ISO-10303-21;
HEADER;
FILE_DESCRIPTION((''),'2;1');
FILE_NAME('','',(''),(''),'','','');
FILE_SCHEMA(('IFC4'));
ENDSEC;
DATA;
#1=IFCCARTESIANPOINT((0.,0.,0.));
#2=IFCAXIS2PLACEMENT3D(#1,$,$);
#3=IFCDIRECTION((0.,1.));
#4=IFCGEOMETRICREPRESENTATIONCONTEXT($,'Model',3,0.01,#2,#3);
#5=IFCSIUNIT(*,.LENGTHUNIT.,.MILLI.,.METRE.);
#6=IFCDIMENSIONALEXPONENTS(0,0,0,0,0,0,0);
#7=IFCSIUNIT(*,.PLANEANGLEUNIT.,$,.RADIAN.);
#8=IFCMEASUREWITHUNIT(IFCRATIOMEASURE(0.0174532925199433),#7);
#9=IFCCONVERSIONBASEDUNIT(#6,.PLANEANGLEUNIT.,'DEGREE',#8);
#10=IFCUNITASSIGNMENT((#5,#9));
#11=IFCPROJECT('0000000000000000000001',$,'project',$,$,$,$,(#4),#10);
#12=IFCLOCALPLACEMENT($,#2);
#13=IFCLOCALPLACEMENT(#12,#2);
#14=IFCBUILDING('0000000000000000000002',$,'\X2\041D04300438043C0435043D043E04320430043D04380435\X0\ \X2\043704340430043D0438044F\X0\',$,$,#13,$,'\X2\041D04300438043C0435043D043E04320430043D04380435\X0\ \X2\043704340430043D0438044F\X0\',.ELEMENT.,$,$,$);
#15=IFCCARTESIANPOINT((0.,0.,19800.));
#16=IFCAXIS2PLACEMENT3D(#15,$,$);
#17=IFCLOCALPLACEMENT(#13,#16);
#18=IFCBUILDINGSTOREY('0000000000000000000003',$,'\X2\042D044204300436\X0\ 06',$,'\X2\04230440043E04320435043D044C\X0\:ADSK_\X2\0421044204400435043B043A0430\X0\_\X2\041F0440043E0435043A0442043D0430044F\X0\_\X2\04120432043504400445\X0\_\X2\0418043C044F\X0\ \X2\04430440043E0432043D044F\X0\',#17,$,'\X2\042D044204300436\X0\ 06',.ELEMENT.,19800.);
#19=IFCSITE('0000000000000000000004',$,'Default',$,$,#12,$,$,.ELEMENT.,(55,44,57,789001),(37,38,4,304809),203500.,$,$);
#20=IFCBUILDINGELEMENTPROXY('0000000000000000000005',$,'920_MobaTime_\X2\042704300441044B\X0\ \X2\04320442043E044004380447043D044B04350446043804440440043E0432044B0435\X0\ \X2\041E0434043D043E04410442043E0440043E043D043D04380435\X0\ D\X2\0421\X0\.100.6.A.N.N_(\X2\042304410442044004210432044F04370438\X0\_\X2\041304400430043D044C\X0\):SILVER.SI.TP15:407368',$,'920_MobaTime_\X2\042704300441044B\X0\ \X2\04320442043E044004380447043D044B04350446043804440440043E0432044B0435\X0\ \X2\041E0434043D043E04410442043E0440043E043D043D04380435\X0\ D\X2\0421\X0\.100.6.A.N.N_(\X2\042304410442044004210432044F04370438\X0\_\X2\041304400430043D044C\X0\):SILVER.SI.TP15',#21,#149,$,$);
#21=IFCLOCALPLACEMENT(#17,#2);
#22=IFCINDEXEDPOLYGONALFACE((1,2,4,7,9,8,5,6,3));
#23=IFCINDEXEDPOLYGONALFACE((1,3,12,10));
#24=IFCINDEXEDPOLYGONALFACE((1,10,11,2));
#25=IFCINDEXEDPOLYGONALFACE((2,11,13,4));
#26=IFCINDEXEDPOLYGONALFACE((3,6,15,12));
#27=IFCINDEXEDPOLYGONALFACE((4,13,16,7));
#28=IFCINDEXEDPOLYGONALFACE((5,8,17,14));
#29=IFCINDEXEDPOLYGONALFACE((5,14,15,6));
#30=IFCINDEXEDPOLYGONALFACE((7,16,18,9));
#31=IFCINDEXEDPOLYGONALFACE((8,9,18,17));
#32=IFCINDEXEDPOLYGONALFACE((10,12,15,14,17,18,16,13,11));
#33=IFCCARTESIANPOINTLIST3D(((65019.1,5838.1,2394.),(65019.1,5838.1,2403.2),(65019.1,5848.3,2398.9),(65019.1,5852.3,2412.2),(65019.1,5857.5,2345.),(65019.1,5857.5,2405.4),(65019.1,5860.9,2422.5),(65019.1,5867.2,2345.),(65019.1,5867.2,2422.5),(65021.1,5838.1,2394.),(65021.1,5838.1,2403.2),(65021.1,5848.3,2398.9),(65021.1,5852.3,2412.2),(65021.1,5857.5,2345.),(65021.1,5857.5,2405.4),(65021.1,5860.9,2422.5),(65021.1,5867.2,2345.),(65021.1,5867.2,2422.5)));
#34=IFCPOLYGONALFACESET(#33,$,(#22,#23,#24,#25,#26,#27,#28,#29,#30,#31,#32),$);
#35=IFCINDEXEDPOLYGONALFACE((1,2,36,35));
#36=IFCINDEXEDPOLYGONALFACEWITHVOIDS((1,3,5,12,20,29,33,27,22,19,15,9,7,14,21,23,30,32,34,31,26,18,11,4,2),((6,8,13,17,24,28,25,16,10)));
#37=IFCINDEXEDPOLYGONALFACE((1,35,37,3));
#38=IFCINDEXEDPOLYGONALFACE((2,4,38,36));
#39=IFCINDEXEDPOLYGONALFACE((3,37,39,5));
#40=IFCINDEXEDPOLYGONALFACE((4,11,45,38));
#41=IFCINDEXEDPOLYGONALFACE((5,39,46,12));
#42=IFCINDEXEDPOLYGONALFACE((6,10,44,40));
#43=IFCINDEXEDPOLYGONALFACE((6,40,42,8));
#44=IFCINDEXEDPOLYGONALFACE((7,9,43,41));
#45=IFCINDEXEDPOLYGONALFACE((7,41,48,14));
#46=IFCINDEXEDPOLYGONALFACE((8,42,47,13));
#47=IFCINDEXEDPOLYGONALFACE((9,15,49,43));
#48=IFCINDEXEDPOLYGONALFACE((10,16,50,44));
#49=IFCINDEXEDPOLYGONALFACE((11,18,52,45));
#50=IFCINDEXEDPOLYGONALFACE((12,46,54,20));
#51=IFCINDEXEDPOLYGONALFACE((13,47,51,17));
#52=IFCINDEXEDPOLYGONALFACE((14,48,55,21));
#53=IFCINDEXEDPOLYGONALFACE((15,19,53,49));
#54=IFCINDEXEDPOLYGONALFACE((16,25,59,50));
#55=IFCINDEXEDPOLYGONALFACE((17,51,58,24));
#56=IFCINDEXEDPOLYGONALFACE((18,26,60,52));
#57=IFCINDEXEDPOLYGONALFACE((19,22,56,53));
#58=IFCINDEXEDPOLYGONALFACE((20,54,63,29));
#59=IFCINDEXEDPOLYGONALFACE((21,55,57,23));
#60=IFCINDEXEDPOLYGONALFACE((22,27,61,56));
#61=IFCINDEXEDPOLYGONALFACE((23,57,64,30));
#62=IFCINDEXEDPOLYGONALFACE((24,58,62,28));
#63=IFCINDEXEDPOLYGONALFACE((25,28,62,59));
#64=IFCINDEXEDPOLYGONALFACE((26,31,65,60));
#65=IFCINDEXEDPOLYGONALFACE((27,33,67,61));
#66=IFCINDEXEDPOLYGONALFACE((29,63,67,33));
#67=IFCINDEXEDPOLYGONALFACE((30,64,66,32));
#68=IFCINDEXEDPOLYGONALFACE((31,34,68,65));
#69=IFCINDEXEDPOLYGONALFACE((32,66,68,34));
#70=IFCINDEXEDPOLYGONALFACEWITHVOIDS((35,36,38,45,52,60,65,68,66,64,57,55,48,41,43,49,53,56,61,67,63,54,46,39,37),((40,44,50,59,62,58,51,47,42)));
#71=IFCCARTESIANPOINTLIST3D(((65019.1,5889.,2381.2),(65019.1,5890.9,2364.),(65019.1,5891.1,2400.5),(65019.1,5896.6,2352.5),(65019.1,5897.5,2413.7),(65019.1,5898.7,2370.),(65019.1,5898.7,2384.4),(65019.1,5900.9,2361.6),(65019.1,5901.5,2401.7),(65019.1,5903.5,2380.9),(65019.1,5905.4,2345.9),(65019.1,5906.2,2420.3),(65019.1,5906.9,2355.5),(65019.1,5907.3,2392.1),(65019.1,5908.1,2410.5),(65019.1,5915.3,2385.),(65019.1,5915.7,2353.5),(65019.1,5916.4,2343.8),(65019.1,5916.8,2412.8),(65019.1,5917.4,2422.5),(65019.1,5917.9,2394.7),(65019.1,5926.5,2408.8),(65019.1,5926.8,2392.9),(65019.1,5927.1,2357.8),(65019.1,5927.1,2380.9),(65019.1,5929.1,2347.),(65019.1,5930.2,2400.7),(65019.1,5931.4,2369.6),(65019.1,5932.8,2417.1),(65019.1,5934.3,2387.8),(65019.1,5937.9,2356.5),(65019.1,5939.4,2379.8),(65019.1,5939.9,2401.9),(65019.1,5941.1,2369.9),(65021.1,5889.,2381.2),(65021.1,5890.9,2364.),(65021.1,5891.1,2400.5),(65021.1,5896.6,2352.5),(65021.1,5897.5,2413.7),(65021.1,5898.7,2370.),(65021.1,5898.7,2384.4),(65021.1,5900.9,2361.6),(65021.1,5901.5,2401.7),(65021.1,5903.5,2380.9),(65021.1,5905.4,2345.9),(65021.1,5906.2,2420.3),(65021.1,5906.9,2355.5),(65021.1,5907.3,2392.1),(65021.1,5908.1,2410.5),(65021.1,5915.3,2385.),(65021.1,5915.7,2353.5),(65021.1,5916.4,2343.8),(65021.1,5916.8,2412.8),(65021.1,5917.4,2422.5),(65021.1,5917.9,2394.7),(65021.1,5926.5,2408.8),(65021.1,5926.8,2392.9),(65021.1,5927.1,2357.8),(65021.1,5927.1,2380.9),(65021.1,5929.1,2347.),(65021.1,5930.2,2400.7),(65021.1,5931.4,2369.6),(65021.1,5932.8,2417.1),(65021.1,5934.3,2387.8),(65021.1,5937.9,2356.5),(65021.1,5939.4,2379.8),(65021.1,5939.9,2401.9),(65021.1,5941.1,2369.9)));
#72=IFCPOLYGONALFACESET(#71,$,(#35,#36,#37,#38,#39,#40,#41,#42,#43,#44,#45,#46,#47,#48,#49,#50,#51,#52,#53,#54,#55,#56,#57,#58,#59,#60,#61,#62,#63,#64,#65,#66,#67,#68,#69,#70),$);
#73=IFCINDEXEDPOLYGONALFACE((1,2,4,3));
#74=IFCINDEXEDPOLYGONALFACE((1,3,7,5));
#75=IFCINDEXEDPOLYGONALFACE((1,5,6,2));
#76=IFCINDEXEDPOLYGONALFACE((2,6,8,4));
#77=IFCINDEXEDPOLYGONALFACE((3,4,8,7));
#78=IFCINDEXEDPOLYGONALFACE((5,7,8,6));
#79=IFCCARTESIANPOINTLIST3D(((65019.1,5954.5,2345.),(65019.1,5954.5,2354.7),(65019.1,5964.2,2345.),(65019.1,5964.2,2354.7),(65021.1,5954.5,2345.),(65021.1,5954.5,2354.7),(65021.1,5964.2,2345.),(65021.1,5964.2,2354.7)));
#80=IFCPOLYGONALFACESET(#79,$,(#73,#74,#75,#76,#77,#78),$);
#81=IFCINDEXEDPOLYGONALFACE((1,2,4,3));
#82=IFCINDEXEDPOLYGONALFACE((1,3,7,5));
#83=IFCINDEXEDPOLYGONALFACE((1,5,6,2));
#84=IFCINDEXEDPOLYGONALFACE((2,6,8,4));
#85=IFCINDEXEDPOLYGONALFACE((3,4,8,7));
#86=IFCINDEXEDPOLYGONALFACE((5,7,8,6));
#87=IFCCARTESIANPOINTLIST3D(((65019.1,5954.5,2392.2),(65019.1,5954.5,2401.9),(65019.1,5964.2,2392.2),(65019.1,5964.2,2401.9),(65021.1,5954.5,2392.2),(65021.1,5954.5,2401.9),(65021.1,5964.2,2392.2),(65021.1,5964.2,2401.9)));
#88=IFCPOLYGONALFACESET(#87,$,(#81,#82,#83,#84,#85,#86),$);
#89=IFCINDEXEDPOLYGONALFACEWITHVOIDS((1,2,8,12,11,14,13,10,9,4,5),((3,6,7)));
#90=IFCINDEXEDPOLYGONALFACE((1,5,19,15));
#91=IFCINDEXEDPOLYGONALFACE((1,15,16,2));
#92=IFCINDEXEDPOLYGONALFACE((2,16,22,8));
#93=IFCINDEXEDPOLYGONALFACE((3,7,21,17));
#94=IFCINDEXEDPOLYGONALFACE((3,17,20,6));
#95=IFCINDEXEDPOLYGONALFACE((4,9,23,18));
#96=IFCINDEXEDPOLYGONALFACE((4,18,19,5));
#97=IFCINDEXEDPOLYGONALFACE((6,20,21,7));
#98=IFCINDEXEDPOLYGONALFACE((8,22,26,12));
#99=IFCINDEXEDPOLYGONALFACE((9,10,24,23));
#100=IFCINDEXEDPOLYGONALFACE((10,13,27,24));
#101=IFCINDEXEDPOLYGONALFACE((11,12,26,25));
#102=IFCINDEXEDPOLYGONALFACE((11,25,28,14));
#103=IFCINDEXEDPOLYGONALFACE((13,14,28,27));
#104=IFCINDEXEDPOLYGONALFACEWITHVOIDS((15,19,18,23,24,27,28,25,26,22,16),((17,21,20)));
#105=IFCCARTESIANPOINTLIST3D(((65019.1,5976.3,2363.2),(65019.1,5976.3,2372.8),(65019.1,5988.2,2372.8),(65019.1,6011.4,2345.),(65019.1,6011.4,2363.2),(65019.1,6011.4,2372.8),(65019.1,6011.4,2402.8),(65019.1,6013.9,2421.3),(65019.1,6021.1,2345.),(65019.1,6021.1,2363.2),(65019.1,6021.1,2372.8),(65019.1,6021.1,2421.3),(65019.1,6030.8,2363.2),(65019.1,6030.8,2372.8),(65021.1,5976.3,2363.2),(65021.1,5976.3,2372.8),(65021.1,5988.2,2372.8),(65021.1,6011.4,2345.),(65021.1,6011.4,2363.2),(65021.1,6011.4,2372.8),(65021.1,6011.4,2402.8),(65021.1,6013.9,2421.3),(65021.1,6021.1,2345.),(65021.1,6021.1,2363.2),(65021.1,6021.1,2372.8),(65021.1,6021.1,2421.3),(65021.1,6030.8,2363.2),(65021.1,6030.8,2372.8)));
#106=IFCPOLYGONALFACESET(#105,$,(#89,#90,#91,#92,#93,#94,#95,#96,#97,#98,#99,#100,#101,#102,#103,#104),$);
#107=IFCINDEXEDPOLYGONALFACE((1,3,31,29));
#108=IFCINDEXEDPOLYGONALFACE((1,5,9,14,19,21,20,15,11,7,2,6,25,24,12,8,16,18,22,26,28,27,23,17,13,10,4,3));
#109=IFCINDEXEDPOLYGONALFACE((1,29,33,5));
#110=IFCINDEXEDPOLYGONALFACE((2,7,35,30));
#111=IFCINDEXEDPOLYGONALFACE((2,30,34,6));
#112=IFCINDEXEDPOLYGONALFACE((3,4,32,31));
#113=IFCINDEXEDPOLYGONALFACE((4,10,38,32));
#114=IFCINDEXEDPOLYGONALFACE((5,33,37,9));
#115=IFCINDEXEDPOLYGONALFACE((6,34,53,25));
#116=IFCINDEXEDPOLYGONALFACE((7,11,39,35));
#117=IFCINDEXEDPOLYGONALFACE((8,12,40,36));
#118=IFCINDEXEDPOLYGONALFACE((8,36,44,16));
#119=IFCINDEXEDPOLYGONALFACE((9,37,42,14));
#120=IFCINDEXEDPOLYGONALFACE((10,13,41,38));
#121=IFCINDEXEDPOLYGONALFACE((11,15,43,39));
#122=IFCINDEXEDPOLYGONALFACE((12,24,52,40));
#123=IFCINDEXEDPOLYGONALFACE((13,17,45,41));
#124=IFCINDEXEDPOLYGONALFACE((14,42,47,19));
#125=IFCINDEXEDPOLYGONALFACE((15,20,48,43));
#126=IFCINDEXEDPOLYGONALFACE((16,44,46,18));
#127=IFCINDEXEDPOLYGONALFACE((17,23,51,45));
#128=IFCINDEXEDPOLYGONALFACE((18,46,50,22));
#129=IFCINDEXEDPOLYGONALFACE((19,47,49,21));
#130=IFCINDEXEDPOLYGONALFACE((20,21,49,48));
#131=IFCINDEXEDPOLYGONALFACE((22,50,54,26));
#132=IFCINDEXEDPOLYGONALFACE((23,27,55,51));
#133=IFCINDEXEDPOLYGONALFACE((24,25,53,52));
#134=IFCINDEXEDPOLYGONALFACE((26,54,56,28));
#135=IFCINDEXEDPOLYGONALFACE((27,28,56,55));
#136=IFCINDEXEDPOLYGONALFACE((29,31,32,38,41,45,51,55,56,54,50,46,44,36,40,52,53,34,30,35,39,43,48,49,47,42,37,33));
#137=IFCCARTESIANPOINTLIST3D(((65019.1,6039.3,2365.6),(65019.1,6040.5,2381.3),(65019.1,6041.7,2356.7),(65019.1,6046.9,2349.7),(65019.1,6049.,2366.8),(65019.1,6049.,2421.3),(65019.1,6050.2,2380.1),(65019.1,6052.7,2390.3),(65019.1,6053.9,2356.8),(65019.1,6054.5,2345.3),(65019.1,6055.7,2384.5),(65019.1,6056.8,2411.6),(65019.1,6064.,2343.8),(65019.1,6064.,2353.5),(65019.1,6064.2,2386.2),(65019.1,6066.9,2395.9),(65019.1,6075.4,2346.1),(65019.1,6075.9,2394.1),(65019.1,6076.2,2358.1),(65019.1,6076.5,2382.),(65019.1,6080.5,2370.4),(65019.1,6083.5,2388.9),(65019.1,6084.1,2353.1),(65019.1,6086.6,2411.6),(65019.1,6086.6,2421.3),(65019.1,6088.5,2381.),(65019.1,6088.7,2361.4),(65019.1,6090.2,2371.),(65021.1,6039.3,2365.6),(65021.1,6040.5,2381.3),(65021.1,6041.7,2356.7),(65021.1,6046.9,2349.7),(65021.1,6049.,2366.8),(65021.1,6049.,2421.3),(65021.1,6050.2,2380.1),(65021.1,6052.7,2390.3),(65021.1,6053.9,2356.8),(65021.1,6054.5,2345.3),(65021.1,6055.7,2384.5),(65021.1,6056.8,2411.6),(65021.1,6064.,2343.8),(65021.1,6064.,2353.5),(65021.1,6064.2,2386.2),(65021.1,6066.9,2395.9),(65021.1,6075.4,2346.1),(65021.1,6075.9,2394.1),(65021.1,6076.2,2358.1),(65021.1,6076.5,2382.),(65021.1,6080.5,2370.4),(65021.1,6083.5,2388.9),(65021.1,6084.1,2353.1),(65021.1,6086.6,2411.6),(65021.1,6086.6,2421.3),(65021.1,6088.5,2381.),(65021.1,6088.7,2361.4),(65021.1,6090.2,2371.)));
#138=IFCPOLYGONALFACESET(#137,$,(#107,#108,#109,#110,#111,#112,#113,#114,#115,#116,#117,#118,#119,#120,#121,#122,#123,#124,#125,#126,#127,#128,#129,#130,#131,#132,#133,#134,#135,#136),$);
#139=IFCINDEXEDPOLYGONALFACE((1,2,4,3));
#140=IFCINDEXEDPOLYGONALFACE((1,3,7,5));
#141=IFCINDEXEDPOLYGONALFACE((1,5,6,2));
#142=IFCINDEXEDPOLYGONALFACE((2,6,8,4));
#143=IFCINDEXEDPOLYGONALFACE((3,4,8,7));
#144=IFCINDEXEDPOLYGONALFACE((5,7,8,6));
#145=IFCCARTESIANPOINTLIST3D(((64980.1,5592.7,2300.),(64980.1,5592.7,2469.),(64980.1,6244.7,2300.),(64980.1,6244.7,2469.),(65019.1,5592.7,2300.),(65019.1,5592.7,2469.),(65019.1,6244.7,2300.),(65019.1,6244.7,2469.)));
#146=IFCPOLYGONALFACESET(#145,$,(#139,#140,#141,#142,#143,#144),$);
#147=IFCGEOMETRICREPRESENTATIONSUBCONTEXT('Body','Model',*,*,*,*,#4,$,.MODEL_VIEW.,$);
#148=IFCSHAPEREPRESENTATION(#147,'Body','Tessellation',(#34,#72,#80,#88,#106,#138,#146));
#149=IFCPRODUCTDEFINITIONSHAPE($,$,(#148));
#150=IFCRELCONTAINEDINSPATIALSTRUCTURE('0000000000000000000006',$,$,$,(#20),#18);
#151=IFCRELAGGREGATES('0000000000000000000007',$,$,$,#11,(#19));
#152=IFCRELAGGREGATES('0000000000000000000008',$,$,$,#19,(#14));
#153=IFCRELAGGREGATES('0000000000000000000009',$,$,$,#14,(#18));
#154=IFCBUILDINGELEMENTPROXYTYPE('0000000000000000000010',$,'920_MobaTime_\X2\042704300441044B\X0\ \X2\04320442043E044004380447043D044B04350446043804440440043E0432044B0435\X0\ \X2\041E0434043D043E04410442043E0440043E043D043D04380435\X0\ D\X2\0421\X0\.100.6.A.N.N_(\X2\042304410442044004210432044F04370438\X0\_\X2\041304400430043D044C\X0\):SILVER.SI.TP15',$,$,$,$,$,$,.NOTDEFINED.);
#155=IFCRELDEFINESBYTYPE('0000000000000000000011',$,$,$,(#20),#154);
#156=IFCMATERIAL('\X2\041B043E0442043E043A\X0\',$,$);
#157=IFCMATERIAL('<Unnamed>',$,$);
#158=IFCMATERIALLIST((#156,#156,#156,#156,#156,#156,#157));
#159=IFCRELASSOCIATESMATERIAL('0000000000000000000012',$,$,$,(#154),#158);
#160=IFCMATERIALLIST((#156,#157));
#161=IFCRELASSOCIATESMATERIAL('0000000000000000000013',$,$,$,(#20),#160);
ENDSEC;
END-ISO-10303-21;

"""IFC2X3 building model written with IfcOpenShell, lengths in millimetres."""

from ifc_helpers import new_model, entity, si_unit, converted_unit, direction, frame, origin, origin_2d_with_axis, place, context, subcontext, project, spatial, polyline, rectangle, outline, extrude, source, transform, mapped, material, material_list, type_object, type_shapes, element, save


model = new_model("IFC2X3")

# Units and contexts
model_context = context("Model", 3, precision=0.01, world=origin(), true_north=direction((0.0, 1.0)))
body_context = subcontext(model_context, "Body", "Model", "MODEL_VIEW")
ifc_project = project(units=[si_unit("LENGTHUNIT", "METRE", prefix="MILLI"), converted_unit("PLANEANGLEUNIT", "DEGREE", entity("IfcRatioMeasure", 0.0174532925199433), si_unit("PLANEANGLEUNIT", "RADIAN"), dimensions=[0, 0, 0, 0, 0, 0, 0])], contexts=[model_context])

# Site, building, storey
site_placement = place(None, frame((0.0, 0.0, 0.0)))
site = spatial("IfcSite", under=ifc_project, at=site_placement, Name="Default", CompositionType="ELEMENT", RefLatitude=(55, 44, 57, 789001), RefLongitude=(37, 38, 4, 304809), RefElevation=203500.0)
building_placement = place(site_placement, origin())
building = spatial("IfcBuilding", under=site, at=building_placement, Name="Наименование здания", LongName="Наименование здания", CompositionType="ELEMENT")
storey_placement = place(building_placement, frame((0.0, 0.0, 19800.0)))
storey = spatial("IfcBuildingStorey", under=building, at=storey_placement, Name="Этаж 06", ObjectType="Уровень:ADSK_Стрелка_Проектная_Вверх_Имя уровня", LongName="Этаж 06", CompositionType="ELEMENT", Elevation=19800.0)

# Building element proxy
ifc_material_1 = material(Name="Лоток")
ifc_material_2 = material(Name="<Unnamed>")
ifc_material_list_1 = material_list([ifc_material_1, ifc_material_1, ifc_material_1, ifc_material_1, ifc_material_1, ifc_material_1, ifc_material_2])
building_element_proxy_type_1 = type_object("IfcBuildingElementProxyType", Name="920_MobaTime_Часы вторичныецифровые Односторонние DС.100.6.A.N.N_(УстрСвязи_Грань):SILVER.SI.TP15", PredefinedType="NOTDEFINED", material=ifc_material_list_1)
shared_shape_1 = source(origin(), body_context, "Body", "SweptSolid", [
    extrude(outline(polyline([(-49.3, -13.1), (28.2, -13.1), (28.2, -6.8), (17.9, 1.8), (8.9, 16.0), (-0.3, 16.0), (4.6, 5.8), (11.1, -3.4), (-49.3, -3.4), (-49.3, -13.1)])), frame((-64.6, 9.8, 39.0), z_axis=(0.0, 0.0, 1.0), x_axis=(0.0, 1.0, 0.0)), (0.0, 0.0, 1.0), 2.0),
    extrude(outline(polyline([(2.2, -27.6), (19.0, -27.6), (30.5, -16.1), (33.3, -4.9), (31.0, 5.8), (21.8, 17.2), (5.2, 27.3), (-11.1, 33.0), (-24.0, 32.7), (-33.6, 27.6), (-40.3, 18.6), (-42.8, 5.7), (-38.0, -6.3), (-27.2, -15.0), (-17.5, -17.7), (-8.2, -16.4), (-0.3, -11.9), (5.1, -4.5), (7.3, 6.2), (4.0, 17.2), (18.5, 7.3), (23.6, -2.4), (22.0, -11.4), (14.2, -18.4), (5.3, -18.3), (2.2, -27.6)]), holes=[polyline([(-9.0, 23.3), (-1.3, 14.4), (-2.6, 2.0), (-11.4, -7.0), (-23.4, -6.1), (-32.2, 2.9), (-31.2, 15.1), (-25.6, 22.1), (-17.5, 24.9), (-9.0, 23.3)])]), frame((-2.7, 3.6, 39.0), z_axis=(0.0, 0.0, 1.0), x_axis=(-0.427649, 0.903945, 0.0)), (0.0, 0.0, 1.0), 2.0),
    extrude(rectangle(XDim=9.7, YDim=9.7, at=origin_2d_with_axis()), frame((40.6, -34.7, 39.0)), (0.0, 0.0, 1.0), 2.0),
    extrude(rectangle(XDim=9.7, YDim=9.7, at=origin_2d_with_axis()), frame((40.6, 12.6, 39.0)), (0.0, 0.0, 1.0), 2.0),
    extrude(outline(polyline([(-0.9, -28.1), (8.8, -28.1), (8.8, -9.9), (18.5, -9.9), (18.5, -0.2), (8.8, -0.2), (8.8, 48.3), (1.5, 48.3), (-36.0, -0.2), (-36.0, -9.9), (-0.9, -9.9), (-0.9, -28.1)]), holes=[polyline([(-0.9, -0.2), (-24.1, -0.2), (-0.9, 29.7), (-0.9, -0.2)])]), frame((93.6, -11.4, 39.0)), (0.0, 0.0, 1.0), 2.0),
    extrude(outline(polyline([(3.3, -28.3), (12.5, -28.3), (20.5, -25.0), (26.8, -18.8), (30.7, -10.0), (31.4, 1.6), (26.9, 11.8), (20.1, 18.4), (11.1, 22.3), (1.0, 23.3), (-7.9, 20.4), (-14.9, 14.5), (-18.9, 6.2), (-17.1, -9.0), (-36.7, 0.5), (-29.1, 29.3), (-38.5, 31.7), (-48.1, -4.6), (-11.6, -23.0), (-8.0, -14.0), (-10.8, -7.6), (-10.2, 1.1), (-3.0, 11.8), (9.2, 12.8), (20.0, 5.4), (21.3, -7.5), (15.5, -16.4), (4.6, -18.6), (3.3, -28.3)])), frame((147.1, -8.5, 39.0), z_axis=(0.0, 0.0, 1.0), x_axis=(0.256974, -0.966418, 0.0)), (0.0, 0.0, 1.0), 2.0),
    extrude(rectangle(XDim=652.0, YDim=169.0, at=origin_2d_with_axis()), frame((0.0, 0.0, 0.0), z_axis=(0.0, 0.0, 1.0), x_axis=(-1.0, 0.0, 0.0)), (0.0, 0.0, 1.0), 39.0),
])
type_shapes(building_element_proxy_type_1, [shared_shape_1])
ifc_material_list_2 = material_list([ifc_material_1, ifc_material_2])
proxy_1_placement = place(storey_placement, frame((64980.1, 5918.7, 2384.5), z_axis=(1.0, 0.0, 0.0), x_axis=(0.0, 1.0, 0.0)))
element("IfcBuildingElementProxy", 1, at=proxy_1_placement, inside=storey, type_object=building_element_proxy_type_1, material=ifc_material_list_2, Name="920_MobaTime_Часы вторичныецифровые Односторонние DС.100.6.A.N.N_(УстрСвязи_Грань):SILVER.SI.TP15:407368", ObjectType="920_MobaTime_Часы вторичныецифровые Односторонние DС.100.6.A.N.N_(УстрСвязи_Грань):SILVER.SI.TP15", context=body_context, shape_type="MappedRepresentation", body=[
    mapped(shared_shape_1, transform((0.0, 0.0, 0.0), scale=1.0)),
])

save(model, "model.ifc")
